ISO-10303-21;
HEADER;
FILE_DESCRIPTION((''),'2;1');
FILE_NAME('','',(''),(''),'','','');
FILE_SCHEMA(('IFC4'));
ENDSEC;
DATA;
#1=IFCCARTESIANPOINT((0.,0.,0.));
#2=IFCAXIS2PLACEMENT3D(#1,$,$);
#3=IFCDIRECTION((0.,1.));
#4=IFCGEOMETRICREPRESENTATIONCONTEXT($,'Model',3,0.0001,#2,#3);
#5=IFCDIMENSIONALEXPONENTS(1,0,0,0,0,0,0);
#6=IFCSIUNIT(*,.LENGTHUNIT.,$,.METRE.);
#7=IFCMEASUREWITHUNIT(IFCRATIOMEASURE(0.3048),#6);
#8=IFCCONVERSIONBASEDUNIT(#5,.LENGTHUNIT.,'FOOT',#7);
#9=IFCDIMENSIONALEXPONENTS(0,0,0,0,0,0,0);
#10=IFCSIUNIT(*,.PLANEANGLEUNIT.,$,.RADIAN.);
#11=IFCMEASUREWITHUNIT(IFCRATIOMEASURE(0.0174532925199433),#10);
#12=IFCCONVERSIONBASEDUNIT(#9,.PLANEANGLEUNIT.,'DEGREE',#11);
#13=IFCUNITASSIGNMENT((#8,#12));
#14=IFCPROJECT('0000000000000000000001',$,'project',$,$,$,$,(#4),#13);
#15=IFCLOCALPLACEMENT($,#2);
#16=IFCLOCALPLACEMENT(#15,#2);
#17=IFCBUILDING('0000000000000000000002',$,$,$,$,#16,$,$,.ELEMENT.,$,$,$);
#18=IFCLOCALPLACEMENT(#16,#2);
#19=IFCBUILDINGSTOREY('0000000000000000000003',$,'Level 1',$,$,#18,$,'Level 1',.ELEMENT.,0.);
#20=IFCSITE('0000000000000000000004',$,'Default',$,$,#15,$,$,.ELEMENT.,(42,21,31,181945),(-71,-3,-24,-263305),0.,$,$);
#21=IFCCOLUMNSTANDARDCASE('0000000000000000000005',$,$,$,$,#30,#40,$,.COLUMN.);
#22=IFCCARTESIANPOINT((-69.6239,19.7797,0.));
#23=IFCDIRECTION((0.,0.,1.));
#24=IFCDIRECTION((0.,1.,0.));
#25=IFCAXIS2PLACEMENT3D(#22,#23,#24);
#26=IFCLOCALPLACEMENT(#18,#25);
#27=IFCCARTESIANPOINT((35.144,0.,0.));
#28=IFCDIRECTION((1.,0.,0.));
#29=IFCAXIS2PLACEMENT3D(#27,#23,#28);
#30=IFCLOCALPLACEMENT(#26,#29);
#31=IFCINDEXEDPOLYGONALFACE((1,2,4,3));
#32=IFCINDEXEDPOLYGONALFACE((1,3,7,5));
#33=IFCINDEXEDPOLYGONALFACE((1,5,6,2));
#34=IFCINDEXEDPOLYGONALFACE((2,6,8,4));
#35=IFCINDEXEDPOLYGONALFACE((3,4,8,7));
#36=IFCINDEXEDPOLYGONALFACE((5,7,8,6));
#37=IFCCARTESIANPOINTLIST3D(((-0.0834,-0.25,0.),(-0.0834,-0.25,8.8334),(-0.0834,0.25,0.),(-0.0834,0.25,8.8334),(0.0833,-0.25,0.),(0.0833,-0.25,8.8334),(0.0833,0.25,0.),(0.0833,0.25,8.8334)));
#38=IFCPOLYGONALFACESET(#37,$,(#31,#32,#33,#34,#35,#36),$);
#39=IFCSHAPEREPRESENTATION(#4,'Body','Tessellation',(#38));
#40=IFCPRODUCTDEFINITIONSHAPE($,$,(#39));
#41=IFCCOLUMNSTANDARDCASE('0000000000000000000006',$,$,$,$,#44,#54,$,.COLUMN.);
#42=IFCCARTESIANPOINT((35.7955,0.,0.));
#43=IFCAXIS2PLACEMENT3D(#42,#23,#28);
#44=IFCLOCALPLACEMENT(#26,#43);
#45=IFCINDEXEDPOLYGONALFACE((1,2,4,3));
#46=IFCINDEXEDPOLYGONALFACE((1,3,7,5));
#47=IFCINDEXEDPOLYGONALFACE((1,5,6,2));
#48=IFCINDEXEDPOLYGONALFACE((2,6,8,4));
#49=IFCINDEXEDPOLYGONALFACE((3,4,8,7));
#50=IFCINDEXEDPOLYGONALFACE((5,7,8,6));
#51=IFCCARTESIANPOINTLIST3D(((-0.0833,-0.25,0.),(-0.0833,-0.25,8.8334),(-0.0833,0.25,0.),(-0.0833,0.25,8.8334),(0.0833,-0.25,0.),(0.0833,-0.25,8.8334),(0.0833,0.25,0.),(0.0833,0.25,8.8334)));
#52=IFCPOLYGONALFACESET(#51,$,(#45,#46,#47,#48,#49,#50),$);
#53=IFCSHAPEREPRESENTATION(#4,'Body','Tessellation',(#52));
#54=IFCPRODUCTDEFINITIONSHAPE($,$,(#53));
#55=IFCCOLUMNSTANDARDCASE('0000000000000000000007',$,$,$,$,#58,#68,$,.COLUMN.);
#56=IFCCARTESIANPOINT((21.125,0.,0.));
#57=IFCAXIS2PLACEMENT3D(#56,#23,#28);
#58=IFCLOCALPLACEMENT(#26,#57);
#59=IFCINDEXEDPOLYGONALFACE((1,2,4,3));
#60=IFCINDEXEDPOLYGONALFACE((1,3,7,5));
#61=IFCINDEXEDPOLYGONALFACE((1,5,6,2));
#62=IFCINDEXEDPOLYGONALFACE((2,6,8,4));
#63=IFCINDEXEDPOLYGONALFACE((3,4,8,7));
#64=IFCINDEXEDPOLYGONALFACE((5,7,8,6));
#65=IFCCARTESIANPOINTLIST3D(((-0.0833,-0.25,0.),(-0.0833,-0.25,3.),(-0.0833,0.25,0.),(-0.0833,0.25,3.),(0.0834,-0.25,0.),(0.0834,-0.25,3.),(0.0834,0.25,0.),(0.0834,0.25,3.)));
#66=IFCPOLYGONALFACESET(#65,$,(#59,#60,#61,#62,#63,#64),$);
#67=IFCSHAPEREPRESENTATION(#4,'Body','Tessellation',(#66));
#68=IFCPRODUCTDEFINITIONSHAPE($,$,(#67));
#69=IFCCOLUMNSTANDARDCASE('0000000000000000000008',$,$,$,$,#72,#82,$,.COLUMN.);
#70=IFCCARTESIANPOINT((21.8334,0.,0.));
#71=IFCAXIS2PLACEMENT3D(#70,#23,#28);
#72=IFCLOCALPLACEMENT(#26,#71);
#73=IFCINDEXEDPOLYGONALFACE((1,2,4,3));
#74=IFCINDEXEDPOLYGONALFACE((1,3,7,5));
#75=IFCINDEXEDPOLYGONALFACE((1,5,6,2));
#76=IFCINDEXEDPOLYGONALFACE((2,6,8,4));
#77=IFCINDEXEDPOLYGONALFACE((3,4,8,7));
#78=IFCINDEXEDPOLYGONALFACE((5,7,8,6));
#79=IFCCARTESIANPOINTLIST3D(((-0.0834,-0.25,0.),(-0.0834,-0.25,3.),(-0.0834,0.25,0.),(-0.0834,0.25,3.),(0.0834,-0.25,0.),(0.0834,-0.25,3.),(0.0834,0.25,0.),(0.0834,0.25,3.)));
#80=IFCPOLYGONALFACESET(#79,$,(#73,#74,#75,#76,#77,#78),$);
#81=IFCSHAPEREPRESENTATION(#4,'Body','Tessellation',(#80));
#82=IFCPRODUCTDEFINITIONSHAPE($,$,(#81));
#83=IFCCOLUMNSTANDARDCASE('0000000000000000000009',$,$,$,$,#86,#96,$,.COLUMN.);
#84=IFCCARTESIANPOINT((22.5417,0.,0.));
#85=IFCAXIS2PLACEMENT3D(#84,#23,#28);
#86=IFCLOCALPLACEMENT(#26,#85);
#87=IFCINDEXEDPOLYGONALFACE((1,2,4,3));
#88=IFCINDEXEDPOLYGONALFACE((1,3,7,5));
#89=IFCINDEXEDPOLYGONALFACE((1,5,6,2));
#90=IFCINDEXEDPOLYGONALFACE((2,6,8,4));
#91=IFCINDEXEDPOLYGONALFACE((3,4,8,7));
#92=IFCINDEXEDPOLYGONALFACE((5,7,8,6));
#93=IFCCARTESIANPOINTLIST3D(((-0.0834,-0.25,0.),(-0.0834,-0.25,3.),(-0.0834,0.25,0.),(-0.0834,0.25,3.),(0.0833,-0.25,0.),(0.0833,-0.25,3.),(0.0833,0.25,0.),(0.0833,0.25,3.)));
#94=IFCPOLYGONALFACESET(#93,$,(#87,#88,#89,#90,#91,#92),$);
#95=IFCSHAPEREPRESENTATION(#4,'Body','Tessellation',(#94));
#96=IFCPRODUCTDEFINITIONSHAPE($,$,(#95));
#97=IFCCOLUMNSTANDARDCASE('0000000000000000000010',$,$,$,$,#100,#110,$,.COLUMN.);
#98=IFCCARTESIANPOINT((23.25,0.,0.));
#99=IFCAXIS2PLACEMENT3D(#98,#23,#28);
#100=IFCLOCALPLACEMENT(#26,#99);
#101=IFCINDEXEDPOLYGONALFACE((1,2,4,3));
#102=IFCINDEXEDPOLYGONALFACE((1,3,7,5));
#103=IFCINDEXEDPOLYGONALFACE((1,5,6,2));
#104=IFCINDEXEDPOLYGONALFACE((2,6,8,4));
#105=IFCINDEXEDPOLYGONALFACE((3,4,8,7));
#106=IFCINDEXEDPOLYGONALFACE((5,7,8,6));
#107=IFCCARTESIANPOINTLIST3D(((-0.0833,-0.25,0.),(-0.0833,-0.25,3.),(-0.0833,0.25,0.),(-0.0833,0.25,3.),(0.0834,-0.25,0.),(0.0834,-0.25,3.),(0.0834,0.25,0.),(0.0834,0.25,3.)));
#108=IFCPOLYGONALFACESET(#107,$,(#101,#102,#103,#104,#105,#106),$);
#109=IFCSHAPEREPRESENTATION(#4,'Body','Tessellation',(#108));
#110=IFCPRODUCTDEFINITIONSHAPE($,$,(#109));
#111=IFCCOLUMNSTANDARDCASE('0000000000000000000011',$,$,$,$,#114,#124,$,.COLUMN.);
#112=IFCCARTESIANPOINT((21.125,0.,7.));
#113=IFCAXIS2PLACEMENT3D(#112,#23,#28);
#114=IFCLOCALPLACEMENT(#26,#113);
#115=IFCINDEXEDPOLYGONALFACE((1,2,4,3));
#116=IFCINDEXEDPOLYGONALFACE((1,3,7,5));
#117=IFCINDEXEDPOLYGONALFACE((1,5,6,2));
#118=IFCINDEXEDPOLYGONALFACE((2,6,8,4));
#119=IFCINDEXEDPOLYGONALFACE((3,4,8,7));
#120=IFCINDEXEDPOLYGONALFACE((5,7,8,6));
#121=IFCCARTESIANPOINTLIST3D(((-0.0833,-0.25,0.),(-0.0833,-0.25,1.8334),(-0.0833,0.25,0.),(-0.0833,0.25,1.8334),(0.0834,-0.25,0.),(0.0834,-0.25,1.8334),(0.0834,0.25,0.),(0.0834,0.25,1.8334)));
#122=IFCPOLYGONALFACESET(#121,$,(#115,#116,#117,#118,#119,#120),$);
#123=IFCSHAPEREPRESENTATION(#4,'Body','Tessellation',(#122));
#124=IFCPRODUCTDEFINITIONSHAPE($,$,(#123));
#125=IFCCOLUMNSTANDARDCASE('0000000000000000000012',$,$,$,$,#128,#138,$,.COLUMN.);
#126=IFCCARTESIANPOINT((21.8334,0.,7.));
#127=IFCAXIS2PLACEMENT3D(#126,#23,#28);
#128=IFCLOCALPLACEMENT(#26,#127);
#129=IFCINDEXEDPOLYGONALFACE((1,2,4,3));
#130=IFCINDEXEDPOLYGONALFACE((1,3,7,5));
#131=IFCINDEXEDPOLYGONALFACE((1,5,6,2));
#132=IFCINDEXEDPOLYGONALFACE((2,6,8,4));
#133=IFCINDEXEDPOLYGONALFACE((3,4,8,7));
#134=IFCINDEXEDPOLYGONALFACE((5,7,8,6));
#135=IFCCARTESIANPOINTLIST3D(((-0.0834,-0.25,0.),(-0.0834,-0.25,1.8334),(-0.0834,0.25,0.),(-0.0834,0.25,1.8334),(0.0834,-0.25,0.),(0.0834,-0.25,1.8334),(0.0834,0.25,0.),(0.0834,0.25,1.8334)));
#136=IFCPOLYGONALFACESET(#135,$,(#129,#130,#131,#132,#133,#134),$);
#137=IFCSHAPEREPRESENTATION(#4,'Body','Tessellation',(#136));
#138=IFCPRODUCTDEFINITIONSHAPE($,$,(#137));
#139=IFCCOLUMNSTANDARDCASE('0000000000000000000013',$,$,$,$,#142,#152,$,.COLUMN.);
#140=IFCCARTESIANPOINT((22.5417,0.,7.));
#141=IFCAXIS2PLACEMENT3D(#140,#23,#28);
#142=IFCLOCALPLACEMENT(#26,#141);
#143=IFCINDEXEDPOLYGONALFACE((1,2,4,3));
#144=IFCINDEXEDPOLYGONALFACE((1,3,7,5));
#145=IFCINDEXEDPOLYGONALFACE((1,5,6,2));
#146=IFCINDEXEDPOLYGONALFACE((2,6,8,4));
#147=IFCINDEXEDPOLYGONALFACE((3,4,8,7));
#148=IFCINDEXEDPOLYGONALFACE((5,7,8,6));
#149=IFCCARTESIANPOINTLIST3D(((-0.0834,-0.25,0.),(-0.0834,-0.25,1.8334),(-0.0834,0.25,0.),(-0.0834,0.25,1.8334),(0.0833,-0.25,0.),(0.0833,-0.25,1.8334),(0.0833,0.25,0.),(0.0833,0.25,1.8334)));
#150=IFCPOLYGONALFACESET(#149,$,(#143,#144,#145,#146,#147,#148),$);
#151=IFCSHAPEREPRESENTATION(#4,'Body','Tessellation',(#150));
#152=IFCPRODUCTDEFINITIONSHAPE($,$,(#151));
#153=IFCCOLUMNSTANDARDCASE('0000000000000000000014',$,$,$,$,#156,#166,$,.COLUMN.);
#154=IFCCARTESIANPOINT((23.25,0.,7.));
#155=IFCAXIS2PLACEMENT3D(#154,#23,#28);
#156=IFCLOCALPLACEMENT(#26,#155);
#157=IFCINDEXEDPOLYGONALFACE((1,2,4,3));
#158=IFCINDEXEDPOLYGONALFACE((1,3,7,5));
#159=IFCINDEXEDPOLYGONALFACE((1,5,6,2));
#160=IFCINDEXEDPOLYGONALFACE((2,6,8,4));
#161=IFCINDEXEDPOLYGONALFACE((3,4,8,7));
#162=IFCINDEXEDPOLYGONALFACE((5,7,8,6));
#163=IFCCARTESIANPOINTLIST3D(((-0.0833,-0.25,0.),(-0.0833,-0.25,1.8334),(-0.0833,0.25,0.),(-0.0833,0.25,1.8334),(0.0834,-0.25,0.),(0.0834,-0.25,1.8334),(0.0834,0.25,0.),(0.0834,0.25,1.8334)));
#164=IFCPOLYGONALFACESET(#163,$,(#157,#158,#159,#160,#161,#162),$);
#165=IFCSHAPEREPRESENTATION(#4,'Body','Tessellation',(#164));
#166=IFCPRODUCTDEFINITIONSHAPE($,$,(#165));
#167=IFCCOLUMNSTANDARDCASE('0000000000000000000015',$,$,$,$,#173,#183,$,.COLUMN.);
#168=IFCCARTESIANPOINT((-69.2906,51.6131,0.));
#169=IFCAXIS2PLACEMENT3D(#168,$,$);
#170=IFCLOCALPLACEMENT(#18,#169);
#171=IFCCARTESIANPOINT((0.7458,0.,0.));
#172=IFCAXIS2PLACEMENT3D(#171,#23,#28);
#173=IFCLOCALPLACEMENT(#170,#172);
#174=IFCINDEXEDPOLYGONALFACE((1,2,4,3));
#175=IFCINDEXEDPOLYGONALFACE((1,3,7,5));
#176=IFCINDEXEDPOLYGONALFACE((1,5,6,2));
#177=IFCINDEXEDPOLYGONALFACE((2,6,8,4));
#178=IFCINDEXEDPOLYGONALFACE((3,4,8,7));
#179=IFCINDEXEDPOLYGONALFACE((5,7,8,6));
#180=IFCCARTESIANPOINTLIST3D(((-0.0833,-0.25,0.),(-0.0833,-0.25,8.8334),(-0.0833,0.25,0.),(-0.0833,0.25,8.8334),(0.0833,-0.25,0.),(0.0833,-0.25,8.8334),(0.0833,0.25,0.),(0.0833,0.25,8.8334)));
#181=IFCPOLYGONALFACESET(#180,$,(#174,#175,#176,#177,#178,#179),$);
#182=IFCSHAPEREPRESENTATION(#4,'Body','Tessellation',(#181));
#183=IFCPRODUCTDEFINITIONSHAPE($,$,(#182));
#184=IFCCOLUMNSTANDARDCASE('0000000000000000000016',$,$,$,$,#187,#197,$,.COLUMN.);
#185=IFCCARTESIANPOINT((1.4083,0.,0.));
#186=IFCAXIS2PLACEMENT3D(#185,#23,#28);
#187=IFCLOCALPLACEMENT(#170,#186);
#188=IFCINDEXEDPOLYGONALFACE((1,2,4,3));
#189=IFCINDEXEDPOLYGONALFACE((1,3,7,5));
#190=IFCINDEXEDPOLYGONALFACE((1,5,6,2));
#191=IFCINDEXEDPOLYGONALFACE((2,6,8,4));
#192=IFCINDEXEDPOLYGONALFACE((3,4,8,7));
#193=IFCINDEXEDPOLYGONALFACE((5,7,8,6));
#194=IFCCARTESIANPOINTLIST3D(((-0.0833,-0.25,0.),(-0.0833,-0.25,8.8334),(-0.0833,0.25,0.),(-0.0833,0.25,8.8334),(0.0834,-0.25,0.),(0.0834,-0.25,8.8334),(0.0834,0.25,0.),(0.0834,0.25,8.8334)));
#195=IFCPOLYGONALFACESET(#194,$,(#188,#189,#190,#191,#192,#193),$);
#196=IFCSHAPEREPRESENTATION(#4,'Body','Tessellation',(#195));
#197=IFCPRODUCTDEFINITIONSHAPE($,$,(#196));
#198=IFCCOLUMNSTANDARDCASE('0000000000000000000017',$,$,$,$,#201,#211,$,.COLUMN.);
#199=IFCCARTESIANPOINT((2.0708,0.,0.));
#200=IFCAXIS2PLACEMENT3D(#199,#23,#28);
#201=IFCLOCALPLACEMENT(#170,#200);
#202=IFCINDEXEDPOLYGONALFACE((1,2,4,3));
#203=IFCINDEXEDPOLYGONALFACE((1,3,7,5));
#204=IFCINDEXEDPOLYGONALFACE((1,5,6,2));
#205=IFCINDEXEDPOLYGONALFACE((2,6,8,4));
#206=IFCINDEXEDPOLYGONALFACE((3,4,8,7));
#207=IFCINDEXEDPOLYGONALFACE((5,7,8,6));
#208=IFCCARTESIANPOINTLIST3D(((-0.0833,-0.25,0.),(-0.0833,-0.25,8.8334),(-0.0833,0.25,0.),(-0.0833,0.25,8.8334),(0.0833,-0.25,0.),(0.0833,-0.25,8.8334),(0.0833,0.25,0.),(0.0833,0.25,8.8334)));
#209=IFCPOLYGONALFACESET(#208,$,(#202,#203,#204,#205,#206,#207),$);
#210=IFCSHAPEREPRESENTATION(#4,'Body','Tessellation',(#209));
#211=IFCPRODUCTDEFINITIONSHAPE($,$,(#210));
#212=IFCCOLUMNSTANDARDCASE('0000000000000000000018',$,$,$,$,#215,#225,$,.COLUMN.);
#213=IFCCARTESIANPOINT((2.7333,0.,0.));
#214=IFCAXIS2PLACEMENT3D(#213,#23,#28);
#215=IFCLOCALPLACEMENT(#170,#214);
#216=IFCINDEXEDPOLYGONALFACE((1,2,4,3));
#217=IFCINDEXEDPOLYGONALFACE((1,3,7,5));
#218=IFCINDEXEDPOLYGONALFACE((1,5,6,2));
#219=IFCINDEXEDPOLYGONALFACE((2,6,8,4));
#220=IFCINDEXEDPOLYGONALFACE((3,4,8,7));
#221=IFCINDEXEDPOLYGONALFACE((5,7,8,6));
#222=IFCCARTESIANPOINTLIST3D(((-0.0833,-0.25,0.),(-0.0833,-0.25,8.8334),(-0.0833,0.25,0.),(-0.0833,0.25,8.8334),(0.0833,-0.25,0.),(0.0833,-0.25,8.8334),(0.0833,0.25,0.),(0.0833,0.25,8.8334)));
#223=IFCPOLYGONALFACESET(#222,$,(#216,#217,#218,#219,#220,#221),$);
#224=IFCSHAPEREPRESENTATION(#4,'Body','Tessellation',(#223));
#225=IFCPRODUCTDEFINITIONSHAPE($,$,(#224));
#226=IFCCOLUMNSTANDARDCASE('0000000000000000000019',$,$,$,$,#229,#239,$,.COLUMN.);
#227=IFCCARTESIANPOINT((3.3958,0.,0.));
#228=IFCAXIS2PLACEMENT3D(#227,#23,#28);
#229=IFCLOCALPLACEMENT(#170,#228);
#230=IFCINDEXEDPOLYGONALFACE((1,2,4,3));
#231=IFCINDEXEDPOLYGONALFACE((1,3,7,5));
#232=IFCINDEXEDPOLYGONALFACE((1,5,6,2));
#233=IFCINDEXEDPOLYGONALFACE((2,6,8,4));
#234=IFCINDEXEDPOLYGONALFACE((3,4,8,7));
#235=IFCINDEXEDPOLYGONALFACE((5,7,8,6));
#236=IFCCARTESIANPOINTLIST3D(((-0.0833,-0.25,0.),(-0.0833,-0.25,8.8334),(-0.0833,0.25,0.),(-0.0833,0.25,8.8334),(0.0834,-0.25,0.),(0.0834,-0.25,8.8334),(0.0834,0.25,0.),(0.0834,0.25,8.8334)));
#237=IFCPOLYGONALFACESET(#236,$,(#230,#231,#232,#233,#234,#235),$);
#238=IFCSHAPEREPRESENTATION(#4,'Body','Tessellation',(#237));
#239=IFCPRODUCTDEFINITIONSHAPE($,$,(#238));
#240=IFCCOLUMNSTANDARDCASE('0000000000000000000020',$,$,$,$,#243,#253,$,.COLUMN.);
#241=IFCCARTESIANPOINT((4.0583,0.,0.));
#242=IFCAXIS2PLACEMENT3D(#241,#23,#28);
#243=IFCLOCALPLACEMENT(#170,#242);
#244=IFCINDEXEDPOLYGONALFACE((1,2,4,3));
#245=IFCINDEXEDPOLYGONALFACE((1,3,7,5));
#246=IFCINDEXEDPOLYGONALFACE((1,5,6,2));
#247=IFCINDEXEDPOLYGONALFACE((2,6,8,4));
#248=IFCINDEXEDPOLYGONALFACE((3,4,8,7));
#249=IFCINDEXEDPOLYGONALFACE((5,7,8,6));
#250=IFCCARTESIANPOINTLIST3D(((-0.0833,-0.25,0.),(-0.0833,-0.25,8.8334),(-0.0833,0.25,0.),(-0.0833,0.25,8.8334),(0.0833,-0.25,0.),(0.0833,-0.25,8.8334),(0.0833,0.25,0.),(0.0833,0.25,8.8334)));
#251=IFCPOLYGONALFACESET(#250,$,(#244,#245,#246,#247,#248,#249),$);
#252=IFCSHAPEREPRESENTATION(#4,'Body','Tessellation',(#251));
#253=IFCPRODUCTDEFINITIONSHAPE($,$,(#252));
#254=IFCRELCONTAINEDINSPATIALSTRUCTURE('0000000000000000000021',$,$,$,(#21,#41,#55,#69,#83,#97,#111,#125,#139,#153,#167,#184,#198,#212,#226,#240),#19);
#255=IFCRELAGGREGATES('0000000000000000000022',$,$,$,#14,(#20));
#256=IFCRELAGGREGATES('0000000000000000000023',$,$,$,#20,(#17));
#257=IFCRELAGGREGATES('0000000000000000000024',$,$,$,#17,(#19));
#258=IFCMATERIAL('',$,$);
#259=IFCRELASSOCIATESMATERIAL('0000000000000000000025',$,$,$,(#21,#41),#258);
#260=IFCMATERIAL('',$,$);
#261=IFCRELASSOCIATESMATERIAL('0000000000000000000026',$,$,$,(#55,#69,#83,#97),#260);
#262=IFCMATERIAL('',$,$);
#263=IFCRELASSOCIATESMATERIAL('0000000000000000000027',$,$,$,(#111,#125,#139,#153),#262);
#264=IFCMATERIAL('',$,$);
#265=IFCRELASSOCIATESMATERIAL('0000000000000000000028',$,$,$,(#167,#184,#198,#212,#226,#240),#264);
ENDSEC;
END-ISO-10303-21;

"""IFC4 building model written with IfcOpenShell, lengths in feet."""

from ifc_helpers import new_model, entity, si_unit, converted_unit, direction, frame, origin, place, context, project, spatial, rectangle, extrude, material, element, save


model = new_model("IFC4")

# Units and contexts
model_context = context("Model", 3, precision=0.0001, world=origin(), true_north=direction((0.0, 1.0)))
ifc_project = project(units=[converted_unit("LENGTHUNIT", "FOOT", entity("IfcRatioMeasure", 0.3048), si_unit("LENGTHUNIT", "METRE"), dimensions=[1, 0, 0, 0, 0, 0, 0]), converted_unit("PLANEANGLEUNIT", "DEGREE", entity("IfcRatioMeasure", 0.0174532925199433), si_unit("PLANEANGLEUNIT", "RADIAN"), dimensions=[0, 0, 0, 0, 0, 0, 0])], contexts=[model_context])

# Site, building, storey
site_placement = place(None, origin())
site = spatial("IfcSite", under=ifc_project, at=site_placement, Name="Default", CompositionType="ELEMENT", RefLatitude=(42, 21, 31, 181945), RefLongitude=(-71, -3, -24, -263305), RefElevation=0.0)
building_placement = place(site_placement, origin())
building = spatial("IfcBuilding", under=site, at=building_placement, CompositionType="ELEMENT")
storey_placement = place(building_placement, origin())
storey = spatial("IfcBuildingStorey", under=building, at=storey_placement, Name="Level 1", LongName="Level 1", CompositionType="ELEMENT", Elevation=0.0)

# Columns
ifc_material_1 = material(Name="")
placement_1 = place(storey_placement, frame((-69.6239, 19.7797, 0.0), z_axis=(0.0, 0.0, 1.0), x_axis=(0.0, 1.0, 0.0)))
for number, where, z_axis, x_axis in (
    (1, (35.144, 0.0, 0.0), (0.0, 0.0, 1.0), (1.0, 0.0, 0.0)),
    (2, (35.7955, 0.0, 0.0), (0.0, 0.0, 1.0), (1.0, 0.0, 0.0)),
):
    element("IfcColumnStandardCase", number, at=place(placement_1, frame(where, z_axis=z_axis, x_axis=x_axis)), inside=storey, material=ifc_material_1, PredefinedType="COLUMN", context=model_context, shape_type="SweptSolid", body=[
        extrude(rectangle(XDim=0.1667, YDim=0.5), origin(), (0.0, 0.0, 1.0), 8.8334),
    ])
ifc_material_2 = material(Name="")
for number, where, z_axis, x_axis in (
    (3, (21.125, 0.0, 0.0), (0.0, 0.0, 1.0), (1.0, 0.0, 0.0)),
    (4, (21.8334, 0.0, 0.0), (0.0, 0.0, 1.0), (1.0, 0.0, 0.0)),
    (5, (22.5417, 0.0, 0.0), (0.0, 0.0, 1.0), (1.0, 0.0, 0.0)),
    (6, (23.25, 0.0, 0.0), (0.0, 0.0, 1.0), (1.0, 0.0, 0.0)),
):
    element("IfcColumnStandardCase", number, at=place(placement_1, frame(where, z_axis=z_axis, x_axis=x_axis)), inside=storey, material=ifc_material_2, PredefinedType="COLUMN", context=model_context, shape_type="SweptSolid", body=[
        extrude(rectangle(XDim=0.1667, YDim=0.5), origin(), (0.0, 0.0, 1.0), 3.0),
    ])
ifc_material_3 = material(Name="")
for number, where, z_axis, x_axis in (
    (7, (21.125, 0.0, 7.0), (0.0, 0.0, 1.0), (1.0, 0.0, 0.0)),
    (8, (21.8334, 0.0, 7.0), (0.0, 0.0, 1.0), (1.0, 0.0, 0.0)),
    (9, (22.5417, 0.0, 7.0), (0.0, 0.0, 1.0), (1.0, 0.0, 0.0)),
    (10, (23.25, 0.0, 7.0), (0.0, 0.0, 1.0), (1.0, 0.0, 0.0)),
):
    element("IfcColumnStandardCase", number, at=place(placement_1, frame(where, z_axis=z_axis, x_axis=x_axis)), inside=storey, material=ifc_material_3, PredefinedType="COLUMN", context=model_context, shape_type="SweptSolid", body=[
        extrude(rectangle(XDim=0.1667, YDim=0.5), origin(), (0.0, 0.0, 1.0), 1.8334),
    ])
ifc_material_4 = material(Name="")
placement_2 = place(storey_placement, frame((-69.2906, 51.6131, 0.0)))
for number, where, z_axis, x_axis in (
    (11, (0.7458, 0.0, 0.0), (0.0, 0.0, 1.0), (1.0, 0.0, 0.0)),
    (12, (1.4083, 0.0, 0.0), (0.0, 0.0, 1.0), (1.0, 0.0, 0.0)),
    (13, (2.0708, 0.0, 0.0), (0.0, 0.0, 1.0), (1.0, 0.0, 0.0)),
    (14, (2.7333, 0.0, 0.0), (0.0, 0.0, 1.0), (1.0, 0.0, 0.0)),
    (15, (3.3958, 0.0, 0.0), (0.0, 0.0, 1.0), (1.0, 0.0, 0.0)),
    (16, (4.0583, 0.0, 0.0), (0.0, 0.0, 1.0), (1.0, 0.0, 0.0)),
):
    element("IfcColumnStandardCase", number, at=place(placement_2, frame(where, z_axis=z_axis, x_axis=x_axis)), inside=storey, material=ifc_material_4, PredefinedType="COLUMN", context=model_context, shape_type="SweptSolid", body=[
        extrude(rectangle(XDim=0.1667, YDim=0.5), origin(), (0.0, 0.0, 1.0), 8.8334),
    ])

save(model, "model.ifc")
